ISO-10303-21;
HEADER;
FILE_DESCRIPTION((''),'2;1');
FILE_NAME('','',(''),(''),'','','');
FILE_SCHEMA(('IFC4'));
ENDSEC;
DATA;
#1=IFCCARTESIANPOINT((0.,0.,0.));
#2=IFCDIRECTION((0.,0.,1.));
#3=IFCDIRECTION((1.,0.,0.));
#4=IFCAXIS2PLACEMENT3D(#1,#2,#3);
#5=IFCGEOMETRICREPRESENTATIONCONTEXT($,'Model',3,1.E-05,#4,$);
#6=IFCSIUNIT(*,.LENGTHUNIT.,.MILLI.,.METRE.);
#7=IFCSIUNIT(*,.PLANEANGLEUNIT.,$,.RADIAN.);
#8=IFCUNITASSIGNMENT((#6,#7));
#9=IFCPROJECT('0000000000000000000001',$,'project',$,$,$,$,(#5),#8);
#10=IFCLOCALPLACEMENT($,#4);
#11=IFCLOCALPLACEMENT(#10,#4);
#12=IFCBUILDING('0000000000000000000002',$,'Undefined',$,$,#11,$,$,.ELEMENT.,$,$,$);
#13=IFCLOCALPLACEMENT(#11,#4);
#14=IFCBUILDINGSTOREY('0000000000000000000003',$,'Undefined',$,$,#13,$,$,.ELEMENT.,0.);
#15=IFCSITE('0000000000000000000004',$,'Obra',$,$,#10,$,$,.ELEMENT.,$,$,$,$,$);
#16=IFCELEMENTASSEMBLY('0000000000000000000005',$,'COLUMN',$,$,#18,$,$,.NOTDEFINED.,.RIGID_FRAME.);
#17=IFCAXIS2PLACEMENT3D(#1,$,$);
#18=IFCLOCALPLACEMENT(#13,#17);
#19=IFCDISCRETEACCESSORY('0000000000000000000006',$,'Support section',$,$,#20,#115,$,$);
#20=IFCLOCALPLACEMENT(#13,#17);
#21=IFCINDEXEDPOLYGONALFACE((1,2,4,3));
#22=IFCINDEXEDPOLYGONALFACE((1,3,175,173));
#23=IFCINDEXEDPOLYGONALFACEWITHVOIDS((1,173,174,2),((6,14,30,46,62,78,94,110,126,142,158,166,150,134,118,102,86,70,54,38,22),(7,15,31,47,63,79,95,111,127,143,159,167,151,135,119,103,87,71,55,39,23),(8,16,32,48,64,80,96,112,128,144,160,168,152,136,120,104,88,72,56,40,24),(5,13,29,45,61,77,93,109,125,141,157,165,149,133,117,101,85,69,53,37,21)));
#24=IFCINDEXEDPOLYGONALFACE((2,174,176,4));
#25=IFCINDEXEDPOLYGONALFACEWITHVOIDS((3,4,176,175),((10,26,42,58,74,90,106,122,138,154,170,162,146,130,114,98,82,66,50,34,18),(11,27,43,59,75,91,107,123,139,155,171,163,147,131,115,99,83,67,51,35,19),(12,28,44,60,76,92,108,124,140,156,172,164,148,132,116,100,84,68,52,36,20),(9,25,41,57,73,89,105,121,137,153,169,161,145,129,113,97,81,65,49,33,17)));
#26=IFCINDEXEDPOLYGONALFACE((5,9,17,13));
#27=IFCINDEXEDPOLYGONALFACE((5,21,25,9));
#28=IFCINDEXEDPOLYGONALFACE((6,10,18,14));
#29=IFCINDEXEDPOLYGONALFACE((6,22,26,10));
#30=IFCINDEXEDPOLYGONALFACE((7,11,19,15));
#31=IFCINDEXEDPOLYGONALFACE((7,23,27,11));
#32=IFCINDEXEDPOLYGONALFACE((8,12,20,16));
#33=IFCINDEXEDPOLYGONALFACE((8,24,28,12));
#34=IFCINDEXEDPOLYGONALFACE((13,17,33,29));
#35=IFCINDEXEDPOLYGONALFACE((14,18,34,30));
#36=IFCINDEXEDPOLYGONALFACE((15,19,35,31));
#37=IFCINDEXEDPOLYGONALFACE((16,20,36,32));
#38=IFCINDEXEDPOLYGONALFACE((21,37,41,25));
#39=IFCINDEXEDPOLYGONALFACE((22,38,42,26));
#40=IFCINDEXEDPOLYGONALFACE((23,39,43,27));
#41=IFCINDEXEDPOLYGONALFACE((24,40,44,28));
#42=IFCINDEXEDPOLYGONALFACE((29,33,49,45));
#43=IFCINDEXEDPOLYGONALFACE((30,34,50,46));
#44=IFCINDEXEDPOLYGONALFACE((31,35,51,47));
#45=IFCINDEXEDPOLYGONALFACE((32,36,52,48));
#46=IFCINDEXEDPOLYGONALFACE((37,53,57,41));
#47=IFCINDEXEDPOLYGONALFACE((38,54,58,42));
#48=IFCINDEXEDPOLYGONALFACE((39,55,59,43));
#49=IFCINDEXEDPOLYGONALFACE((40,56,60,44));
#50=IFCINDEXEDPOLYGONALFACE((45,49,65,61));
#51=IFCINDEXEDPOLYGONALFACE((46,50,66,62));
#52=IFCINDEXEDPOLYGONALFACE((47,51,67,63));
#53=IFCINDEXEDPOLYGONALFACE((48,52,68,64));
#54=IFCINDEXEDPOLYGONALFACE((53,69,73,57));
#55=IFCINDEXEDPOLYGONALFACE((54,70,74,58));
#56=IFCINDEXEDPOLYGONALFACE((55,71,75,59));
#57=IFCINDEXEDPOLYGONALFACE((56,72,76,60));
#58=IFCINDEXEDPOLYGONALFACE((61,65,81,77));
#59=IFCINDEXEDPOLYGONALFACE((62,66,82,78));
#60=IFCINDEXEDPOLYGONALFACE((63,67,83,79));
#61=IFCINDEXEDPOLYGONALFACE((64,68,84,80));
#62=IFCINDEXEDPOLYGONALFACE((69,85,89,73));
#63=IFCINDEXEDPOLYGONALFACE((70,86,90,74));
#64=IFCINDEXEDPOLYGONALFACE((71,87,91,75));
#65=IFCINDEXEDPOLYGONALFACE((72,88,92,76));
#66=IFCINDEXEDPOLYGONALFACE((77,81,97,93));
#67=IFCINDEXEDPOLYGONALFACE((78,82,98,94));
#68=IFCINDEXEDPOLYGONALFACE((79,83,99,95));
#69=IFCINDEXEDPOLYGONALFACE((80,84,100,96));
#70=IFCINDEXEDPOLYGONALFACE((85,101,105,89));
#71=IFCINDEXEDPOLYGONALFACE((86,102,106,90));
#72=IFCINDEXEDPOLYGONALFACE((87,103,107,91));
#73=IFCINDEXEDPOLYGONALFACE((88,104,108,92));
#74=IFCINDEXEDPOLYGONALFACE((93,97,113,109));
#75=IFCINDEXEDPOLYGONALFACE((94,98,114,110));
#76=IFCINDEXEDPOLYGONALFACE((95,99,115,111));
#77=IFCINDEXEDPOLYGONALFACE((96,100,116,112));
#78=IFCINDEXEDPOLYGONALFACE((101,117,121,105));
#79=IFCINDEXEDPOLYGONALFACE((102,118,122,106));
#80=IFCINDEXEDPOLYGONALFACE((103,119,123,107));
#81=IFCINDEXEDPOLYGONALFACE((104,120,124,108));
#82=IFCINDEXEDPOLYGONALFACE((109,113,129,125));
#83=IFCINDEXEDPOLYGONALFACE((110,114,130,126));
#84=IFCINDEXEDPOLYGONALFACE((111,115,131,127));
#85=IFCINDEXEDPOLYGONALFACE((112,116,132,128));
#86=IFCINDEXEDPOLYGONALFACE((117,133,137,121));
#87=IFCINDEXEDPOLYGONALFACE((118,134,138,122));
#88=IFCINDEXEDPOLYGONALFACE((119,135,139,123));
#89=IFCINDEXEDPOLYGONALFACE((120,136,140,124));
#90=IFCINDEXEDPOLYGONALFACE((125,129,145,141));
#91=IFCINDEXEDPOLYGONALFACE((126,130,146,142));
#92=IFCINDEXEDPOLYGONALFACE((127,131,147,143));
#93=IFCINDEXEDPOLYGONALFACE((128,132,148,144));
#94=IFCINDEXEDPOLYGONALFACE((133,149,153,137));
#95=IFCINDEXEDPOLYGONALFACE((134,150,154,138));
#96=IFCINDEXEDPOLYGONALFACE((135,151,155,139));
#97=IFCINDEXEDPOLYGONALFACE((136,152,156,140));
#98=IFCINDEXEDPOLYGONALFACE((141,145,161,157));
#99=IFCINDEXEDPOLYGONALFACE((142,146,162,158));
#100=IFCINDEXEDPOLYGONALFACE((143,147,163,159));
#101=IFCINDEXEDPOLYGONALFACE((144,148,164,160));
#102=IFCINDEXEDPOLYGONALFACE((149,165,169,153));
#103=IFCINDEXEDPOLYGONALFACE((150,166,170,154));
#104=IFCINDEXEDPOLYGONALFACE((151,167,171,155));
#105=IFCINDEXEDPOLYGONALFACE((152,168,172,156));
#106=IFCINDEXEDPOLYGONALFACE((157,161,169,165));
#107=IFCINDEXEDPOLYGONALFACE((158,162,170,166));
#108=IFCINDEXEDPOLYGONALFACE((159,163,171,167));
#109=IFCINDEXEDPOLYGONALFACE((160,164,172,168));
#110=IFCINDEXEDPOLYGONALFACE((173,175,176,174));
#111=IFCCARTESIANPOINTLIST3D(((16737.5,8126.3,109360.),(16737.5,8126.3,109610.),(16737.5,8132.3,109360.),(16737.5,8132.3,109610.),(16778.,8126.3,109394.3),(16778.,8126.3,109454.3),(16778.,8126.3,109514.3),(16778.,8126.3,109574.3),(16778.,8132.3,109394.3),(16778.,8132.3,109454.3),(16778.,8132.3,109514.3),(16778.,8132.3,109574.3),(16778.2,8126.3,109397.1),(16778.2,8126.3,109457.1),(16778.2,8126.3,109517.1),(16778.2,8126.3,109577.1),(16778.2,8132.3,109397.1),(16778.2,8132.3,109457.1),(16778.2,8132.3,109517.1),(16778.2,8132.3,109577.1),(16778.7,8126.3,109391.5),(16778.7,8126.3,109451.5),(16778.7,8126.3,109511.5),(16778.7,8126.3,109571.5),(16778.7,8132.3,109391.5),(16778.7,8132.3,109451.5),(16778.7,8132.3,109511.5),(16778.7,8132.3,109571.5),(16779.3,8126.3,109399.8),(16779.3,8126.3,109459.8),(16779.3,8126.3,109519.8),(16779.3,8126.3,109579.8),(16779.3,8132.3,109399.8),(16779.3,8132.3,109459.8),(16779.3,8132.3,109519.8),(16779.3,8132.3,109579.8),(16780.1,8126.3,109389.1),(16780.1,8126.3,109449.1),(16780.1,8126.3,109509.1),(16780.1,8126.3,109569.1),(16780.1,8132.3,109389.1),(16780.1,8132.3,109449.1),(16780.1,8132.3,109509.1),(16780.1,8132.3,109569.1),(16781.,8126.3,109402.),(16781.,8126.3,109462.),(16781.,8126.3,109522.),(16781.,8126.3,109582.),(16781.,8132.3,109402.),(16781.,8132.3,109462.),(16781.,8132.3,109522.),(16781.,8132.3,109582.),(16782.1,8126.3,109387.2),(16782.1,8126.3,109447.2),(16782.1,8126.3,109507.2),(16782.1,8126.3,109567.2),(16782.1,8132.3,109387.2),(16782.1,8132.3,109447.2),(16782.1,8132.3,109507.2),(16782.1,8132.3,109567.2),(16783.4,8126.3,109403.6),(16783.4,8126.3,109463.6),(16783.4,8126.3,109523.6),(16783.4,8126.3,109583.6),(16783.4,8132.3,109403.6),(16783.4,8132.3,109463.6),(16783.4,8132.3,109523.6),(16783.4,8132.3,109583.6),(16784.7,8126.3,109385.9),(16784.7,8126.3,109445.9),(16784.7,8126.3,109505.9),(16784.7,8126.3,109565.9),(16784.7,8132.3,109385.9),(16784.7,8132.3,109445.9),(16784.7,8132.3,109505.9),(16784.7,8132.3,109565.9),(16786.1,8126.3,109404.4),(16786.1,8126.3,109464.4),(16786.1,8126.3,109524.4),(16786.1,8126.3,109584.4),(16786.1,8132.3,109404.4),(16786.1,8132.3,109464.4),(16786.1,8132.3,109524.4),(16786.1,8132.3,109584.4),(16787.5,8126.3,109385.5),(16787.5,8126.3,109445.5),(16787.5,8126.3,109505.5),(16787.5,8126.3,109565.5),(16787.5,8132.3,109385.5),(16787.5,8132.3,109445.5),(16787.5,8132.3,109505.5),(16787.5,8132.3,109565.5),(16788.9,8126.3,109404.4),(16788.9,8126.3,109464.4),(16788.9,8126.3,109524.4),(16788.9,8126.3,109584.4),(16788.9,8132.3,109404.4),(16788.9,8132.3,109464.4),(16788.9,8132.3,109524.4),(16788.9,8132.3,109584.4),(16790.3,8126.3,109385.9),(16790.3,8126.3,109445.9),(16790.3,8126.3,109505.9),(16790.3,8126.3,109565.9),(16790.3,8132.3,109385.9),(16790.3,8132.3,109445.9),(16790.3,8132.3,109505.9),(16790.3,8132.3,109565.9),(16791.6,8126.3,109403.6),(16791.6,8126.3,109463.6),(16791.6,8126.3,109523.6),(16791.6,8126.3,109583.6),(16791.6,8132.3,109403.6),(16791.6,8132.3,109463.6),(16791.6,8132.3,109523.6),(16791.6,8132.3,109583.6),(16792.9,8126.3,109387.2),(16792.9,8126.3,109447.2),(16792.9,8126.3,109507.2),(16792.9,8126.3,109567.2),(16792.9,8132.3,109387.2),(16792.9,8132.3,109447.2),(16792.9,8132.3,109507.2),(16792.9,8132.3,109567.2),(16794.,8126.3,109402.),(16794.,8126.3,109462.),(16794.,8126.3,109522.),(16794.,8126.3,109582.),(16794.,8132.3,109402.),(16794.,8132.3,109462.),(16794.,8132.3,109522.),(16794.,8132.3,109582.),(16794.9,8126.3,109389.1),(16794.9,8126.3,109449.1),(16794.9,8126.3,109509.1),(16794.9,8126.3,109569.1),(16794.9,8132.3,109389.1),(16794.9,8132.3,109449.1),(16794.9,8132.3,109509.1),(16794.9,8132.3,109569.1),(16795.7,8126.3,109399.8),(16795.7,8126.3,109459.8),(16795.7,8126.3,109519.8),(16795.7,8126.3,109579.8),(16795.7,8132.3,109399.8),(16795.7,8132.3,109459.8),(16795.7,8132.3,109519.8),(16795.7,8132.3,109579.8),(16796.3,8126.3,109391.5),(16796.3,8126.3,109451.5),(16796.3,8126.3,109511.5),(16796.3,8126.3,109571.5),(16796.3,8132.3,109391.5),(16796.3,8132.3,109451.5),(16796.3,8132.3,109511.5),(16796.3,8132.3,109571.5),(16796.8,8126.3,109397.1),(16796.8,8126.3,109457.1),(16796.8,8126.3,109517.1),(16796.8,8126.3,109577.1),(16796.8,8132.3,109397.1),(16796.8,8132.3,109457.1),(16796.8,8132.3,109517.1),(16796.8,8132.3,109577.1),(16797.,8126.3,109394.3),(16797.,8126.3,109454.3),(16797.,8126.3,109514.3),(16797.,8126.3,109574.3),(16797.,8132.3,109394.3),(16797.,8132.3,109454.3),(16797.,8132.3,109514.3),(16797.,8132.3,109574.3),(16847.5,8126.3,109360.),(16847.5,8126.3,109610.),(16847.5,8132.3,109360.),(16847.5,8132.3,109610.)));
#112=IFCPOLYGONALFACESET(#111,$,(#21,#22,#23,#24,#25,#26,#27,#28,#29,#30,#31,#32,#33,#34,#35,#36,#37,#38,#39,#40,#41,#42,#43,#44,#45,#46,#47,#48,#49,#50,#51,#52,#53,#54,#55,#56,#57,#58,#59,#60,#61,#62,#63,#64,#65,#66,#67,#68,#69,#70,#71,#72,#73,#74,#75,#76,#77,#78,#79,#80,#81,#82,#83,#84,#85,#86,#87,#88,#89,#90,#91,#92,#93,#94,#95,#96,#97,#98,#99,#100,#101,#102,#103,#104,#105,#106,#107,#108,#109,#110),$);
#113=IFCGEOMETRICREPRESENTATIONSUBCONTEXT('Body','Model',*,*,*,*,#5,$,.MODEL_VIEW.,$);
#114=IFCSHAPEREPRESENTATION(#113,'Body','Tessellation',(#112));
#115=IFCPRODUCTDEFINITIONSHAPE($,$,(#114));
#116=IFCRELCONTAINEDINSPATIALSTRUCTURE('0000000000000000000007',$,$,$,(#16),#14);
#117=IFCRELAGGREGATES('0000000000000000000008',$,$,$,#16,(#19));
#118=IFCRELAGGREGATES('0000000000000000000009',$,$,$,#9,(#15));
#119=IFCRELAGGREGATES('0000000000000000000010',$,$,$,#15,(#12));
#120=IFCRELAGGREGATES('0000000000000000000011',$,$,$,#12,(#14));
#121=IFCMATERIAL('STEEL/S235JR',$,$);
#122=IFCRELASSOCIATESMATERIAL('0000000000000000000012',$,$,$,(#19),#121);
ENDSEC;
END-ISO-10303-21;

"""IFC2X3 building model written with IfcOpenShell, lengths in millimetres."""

from ifc_helpers import new_model, si_unit, frame, origin_with_axes, origin_2d_with_axis, place, context, subcontext, project, spatial, rectangle, circle, extrude, source, transform, mapped, material, element, aggregate, save


model = new_model("IFC2X3")

# Units and contexts
model_context = context("Model", 3, precision=1e-05, world=origin_with_axes())
body_context = subcontext(model_context, "Body", "Model", "MODEL_VIEW")
ifc_project = project(units=[si_unit("LENGTHUNIT", "METRE", prefix="MILLI"), si_unit("PLANEANGLEUNIT", "RADIAN")], contexts=[model_context])

# Site, building, storey
site_placement = place(None, origin_with_axes())
site = spatial("IfcSite", under=ifc_project, at=site_placement, Name="Obra", CompositionType="ELEMENT")
building_placement = place(site_placement, origin_with_axes())
building = spatial("IfcBuilding", under=site, at=building_placement, Name="Undefined", CompositionType="ELEMENT")
storey_placement = place(building_placement, origin_with_axes())
storey = spatial("IfcBuildingStorey", under=building, at=storey_placement, Name="Undefined", CompositionType="ELEMENT", Elevation=0.0)

# Element assembly
assembly_1_placement = place(storey_placement, origin_with_axes())
assembly_1 = element("IfcElementAssembly", 1, at=assembly_1_placement, inside=storey, Name="COLUMN", AssemblyPlace="NOTDEFINED", PredefinedType="RIGID_FRAME")
ifc_material_1 = material(Name="STEEL/S235JR")

# Shared definitions
shared_shape_1 = source(origin_with_axes(), body_context, "Body", "SweptSolid", [
    extrude(circle(Radius=9.5, at=origin_2d_with_axis()), frame((0.0, -9.9, 0.0), z_axis=(0.0, 1.0, 0.0), x_axis=(1.0, 0.0, 0.0)), (0.0, 0.0, 1.0), 6.2),
])

# Discrete accessory, opening
discrete_accessory_1_placement = place(assembly_1_placement, frame((16792.5, 8129.3, 109360.0), z_axis=(0.0, 0.0, 1.0), x_axis=(1.0, 0.0, 0.0)))
discrete_accessory_1 = element("IfcDiscreteAccessory", 2, at=discrete_accessory_1_placement, material=ifc_material_1, Name="Support section", context=body_context, shape_type="SweptSolid", body=[
    extrude(rectangle(XDim=6.0, YDim=110.0, at=origin_2d_with_axis()), frame((0.0, 0.0, 250.0), z_axis=(0.0, 0.0, -1.0), x_axis=(0.0, 1.0, 0.0)), (0.0, 0.0, 1.0), 250.0),
])
opening_1_placement = place(assembly_1_placement, frame((16837.5, 8122.5, 109650.0), z_axis=(-1.0, 0.0, 0.0), x_axis=(0.0, 0.0, -1.0)))
element("IfcOpeningElement", 3, at=opening_1_placement, cuts=discrete_accessory_1, ObjectType="Opening", context=body_context, shape_type="MappedRepresentation", body=[
    mapped(shared_shape_1, transform((75.0, 0.0, 50.0))),
    mapped(shared_shape_1, transform((135.0, 0.0, 50.0))),
    mapped(shared_shape_1, transform((195.0, 0.0, 50.0))),
    mapped(shared_shape_1, transform((255.0, 0.0, 50.0))),
])
aggregate(assembly_1, [discrete_accessory_1])

save(model, "model.ifc")
